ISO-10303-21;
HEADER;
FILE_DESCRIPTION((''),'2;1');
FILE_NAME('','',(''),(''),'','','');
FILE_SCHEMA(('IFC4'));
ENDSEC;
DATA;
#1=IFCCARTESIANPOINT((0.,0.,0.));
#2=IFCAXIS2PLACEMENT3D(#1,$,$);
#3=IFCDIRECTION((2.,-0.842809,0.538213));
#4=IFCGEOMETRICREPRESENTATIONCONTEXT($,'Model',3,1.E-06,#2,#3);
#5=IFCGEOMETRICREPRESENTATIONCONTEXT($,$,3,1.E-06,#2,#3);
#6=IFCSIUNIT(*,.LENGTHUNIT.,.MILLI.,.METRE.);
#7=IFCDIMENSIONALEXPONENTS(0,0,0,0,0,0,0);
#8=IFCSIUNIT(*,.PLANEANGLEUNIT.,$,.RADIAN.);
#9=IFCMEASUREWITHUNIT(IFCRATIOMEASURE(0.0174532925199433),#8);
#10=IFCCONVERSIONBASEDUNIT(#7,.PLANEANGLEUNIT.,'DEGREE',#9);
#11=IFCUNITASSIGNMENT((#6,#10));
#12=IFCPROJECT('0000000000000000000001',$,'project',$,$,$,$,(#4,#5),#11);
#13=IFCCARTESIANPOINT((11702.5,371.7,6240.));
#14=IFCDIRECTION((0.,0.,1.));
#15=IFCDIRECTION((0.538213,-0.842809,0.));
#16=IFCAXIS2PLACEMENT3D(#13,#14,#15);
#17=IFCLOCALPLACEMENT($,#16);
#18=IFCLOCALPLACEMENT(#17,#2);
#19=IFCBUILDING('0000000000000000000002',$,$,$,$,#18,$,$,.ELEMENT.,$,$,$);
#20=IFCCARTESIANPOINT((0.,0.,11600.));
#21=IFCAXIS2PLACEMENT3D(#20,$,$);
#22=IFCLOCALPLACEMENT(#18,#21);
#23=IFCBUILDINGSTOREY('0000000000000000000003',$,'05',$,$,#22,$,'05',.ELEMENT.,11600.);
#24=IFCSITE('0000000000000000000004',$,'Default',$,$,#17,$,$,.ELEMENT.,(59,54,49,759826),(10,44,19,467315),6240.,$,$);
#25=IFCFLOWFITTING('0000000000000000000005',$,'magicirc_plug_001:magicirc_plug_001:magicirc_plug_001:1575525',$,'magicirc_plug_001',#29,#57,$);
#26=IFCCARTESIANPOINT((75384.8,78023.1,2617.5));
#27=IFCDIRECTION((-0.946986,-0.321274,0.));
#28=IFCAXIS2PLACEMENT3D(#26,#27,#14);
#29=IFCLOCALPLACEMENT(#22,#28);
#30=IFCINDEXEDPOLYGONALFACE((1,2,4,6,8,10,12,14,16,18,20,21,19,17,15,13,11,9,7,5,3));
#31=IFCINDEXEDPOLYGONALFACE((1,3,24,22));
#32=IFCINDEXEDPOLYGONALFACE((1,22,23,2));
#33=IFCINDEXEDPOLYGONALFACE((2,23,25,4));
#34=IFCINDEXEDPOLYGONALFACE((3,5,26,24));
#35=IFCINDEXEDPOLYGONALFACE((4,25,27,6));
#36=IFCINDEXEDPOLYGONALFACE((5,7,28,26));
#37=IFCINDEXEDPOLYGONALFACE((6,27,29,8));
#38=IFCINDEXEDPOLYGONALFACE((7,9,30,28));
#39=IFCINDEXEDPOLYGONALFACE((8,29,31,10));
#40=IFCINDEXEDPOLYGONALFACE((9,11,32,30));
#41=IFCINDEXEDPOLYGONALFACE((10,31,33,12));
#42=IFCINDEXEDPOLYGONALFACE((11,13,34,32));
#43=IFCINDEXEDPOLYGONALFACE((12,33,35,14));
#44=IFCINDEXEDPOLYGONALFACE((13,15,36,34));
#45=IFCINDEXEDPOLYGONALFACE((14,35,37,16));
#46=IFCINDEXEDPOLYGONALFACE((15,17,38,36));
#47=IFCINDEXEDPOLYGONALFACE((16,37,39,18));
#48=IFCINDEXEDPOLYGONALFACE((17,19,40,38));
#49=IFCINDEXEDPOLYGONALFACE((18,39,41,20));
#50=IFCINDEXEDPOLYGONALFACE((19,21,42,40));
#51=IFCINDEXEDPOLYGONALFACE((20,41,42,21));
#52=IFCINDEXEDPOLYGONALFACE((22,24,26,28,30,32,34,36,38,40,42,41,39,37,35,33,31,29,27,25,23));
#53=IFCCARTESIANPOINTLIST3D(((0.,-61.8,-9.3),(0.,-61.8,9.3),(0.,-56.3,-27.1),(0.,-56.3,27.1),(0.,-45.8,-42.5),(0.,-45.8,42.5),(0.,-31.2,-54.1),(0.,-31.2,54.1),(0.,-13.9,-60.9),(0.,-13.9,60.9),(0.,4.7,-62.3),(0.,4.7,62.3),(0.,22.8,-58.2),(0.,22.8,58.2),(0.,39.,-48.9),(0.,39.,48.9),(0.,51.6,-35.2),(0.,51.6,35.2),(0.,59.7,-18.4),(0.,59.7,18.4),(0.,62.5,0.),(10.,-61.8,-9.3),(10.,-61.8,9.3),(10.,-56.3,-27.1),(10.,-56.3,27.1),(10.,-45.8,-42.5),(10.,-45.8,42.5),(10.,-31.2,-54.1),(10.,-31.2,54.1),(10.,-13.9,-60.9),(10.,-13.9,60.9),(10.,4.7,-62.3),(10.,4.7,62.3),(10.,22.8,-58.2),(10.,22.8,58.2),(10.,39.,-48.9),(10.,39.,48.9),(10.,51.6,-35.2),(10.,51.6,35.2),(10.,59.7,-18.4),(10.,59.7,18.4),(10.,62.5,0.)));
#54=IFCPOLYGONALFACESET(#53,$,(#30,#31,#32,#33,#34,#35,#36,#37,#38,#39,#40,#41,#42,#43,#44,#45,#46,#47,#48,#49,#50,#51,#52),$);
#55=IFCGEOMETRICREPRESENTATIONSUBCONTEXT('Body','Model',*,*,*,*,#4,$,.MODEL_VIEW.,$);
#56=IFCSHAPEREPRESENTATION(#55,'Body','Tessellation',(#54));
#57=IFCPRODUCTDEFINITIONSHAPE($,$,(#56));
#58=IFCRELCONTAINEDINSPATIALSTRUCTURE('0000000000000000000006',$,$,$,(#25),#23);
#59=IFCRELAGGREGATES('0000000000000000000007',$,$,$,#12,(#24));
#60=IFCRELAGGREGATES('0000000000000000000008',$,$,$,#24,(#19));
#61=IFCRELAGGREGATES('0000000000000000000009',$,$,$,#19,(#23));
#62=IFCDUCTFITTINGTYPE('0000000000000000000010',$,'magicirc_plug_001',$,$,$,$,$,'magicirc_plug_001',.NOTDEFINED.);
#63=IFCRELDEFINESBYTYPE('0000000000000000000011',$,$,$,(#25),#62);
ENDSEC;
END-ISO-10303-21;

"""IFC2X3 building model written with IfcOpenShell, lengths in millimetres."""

from ifc_helpers import new_model, entity, si_unit, converted_unit, direction, frame, frame_2d, origin, place, context, subcontext, project, spatial, circle, extrude, source, transform, mapped, type_object, type_shapes, element, save


model = new_model("IFC2X3")

# Units and contexts
model_context = context("Model", 3, precision=1e-06, world=origin(), true_north=direction((2.0, -0.842809, 0.538213)))
context_of_model = context(None, 3, precision=1e-06, world=origin(), true_north=direction((2.0, -0.842809, 0.538213)))
body_context = subcontext(model_context, "Body", "Model", "MODEL_VIEW")
ifc_project = project(units=[si_unit("LENGTHUNIT", "METRE", prefix="MILLI"), converted_unit("PLANEANGLEUNIT", "DEGREE", entity("IfcRatioMeasure", 0.0174532925199433), si_unit("PLANEANGLEUNIT", "RADIAN"), dimensions=[0, 0, 0, 0, 0, 0, 0])], contexts=[model_context, context_of_model])

# Site, building, storey
site_placement = place(None, frame((11702.5, 371.7, 6240.0), z_axis=(0.0, 0.0, 1.0), x_axis=(0.538213, -0.842809, 0.0)))
site = spatial("IfcSite", under=ifc_project, at=site_placement, Name="Default", CompositionType="ELEMENT", RefLatitude=(59, 54, 49, 759826), RefLongitude=(10, 44, 19, 467315), RefElevation=6240.0)
building_placement = place(site_placement, origin())
building = spatial("IfcBuilding", under=site, at=building_placement, CompositionType="ELEMENT")
storey_placement = place(building_placement, frame((0.0, 0.0, 11600.0)))
storey = spatial("IfcBuildingStorey", under=building, at=storey_placement, Name="05", LongName="05", CompositionType="ELEMENT", Elevation=11600.0)

# Flow fitting
duct_fitting_type_1 = type_object("IfcDuctFittingType", Name="magicirc_plug_001", ElementType="magicirc_plug_001", PredefinedType="NOTDEFINED")
shared_shape_1 = source(origin(), body_context, "Body", "SweptSolid", [
    extrude(circle(Radius=62.5, at=frame_2d((0.0, 0.0), x_axis=(1.0, 0.0))), frame((0.0, 0.0, 0.0), z_axis=(1.0, 0.0, 0.0), x_axis=(0.0, 1.0, 0.0)), (0.0, 0.0, 1.0), 10.0),
])
type_shapes(duct_fitting_type_1, [shared_shape_1])
for number, where, z_axis, x_axis, name in (
    (1, (75384.8, 78023.1, 2617.5), (-0.946986, -0.321274, 0.0), (0.0, 0.0, 1.0), "magicirc_plug_001:magicirc_plug_001:magicirc_plug_001:1575525"),
):
    element("IfcFlowFitting", number, at=place(storey_placement, frame(where, z_axis=z_axis, x_axis=x_axis)), inside=storey, type_object=duct_fitting_type_1, Name=name, ObjectType="magicirc_plug_001", context=body_context, shape_type="MappedRepresentation", body=[
        mapped(shared_shape_1, transform((0.0, 0.0, 0.0), scale=1.0)),
    ])

save(model, "model.ifc")
